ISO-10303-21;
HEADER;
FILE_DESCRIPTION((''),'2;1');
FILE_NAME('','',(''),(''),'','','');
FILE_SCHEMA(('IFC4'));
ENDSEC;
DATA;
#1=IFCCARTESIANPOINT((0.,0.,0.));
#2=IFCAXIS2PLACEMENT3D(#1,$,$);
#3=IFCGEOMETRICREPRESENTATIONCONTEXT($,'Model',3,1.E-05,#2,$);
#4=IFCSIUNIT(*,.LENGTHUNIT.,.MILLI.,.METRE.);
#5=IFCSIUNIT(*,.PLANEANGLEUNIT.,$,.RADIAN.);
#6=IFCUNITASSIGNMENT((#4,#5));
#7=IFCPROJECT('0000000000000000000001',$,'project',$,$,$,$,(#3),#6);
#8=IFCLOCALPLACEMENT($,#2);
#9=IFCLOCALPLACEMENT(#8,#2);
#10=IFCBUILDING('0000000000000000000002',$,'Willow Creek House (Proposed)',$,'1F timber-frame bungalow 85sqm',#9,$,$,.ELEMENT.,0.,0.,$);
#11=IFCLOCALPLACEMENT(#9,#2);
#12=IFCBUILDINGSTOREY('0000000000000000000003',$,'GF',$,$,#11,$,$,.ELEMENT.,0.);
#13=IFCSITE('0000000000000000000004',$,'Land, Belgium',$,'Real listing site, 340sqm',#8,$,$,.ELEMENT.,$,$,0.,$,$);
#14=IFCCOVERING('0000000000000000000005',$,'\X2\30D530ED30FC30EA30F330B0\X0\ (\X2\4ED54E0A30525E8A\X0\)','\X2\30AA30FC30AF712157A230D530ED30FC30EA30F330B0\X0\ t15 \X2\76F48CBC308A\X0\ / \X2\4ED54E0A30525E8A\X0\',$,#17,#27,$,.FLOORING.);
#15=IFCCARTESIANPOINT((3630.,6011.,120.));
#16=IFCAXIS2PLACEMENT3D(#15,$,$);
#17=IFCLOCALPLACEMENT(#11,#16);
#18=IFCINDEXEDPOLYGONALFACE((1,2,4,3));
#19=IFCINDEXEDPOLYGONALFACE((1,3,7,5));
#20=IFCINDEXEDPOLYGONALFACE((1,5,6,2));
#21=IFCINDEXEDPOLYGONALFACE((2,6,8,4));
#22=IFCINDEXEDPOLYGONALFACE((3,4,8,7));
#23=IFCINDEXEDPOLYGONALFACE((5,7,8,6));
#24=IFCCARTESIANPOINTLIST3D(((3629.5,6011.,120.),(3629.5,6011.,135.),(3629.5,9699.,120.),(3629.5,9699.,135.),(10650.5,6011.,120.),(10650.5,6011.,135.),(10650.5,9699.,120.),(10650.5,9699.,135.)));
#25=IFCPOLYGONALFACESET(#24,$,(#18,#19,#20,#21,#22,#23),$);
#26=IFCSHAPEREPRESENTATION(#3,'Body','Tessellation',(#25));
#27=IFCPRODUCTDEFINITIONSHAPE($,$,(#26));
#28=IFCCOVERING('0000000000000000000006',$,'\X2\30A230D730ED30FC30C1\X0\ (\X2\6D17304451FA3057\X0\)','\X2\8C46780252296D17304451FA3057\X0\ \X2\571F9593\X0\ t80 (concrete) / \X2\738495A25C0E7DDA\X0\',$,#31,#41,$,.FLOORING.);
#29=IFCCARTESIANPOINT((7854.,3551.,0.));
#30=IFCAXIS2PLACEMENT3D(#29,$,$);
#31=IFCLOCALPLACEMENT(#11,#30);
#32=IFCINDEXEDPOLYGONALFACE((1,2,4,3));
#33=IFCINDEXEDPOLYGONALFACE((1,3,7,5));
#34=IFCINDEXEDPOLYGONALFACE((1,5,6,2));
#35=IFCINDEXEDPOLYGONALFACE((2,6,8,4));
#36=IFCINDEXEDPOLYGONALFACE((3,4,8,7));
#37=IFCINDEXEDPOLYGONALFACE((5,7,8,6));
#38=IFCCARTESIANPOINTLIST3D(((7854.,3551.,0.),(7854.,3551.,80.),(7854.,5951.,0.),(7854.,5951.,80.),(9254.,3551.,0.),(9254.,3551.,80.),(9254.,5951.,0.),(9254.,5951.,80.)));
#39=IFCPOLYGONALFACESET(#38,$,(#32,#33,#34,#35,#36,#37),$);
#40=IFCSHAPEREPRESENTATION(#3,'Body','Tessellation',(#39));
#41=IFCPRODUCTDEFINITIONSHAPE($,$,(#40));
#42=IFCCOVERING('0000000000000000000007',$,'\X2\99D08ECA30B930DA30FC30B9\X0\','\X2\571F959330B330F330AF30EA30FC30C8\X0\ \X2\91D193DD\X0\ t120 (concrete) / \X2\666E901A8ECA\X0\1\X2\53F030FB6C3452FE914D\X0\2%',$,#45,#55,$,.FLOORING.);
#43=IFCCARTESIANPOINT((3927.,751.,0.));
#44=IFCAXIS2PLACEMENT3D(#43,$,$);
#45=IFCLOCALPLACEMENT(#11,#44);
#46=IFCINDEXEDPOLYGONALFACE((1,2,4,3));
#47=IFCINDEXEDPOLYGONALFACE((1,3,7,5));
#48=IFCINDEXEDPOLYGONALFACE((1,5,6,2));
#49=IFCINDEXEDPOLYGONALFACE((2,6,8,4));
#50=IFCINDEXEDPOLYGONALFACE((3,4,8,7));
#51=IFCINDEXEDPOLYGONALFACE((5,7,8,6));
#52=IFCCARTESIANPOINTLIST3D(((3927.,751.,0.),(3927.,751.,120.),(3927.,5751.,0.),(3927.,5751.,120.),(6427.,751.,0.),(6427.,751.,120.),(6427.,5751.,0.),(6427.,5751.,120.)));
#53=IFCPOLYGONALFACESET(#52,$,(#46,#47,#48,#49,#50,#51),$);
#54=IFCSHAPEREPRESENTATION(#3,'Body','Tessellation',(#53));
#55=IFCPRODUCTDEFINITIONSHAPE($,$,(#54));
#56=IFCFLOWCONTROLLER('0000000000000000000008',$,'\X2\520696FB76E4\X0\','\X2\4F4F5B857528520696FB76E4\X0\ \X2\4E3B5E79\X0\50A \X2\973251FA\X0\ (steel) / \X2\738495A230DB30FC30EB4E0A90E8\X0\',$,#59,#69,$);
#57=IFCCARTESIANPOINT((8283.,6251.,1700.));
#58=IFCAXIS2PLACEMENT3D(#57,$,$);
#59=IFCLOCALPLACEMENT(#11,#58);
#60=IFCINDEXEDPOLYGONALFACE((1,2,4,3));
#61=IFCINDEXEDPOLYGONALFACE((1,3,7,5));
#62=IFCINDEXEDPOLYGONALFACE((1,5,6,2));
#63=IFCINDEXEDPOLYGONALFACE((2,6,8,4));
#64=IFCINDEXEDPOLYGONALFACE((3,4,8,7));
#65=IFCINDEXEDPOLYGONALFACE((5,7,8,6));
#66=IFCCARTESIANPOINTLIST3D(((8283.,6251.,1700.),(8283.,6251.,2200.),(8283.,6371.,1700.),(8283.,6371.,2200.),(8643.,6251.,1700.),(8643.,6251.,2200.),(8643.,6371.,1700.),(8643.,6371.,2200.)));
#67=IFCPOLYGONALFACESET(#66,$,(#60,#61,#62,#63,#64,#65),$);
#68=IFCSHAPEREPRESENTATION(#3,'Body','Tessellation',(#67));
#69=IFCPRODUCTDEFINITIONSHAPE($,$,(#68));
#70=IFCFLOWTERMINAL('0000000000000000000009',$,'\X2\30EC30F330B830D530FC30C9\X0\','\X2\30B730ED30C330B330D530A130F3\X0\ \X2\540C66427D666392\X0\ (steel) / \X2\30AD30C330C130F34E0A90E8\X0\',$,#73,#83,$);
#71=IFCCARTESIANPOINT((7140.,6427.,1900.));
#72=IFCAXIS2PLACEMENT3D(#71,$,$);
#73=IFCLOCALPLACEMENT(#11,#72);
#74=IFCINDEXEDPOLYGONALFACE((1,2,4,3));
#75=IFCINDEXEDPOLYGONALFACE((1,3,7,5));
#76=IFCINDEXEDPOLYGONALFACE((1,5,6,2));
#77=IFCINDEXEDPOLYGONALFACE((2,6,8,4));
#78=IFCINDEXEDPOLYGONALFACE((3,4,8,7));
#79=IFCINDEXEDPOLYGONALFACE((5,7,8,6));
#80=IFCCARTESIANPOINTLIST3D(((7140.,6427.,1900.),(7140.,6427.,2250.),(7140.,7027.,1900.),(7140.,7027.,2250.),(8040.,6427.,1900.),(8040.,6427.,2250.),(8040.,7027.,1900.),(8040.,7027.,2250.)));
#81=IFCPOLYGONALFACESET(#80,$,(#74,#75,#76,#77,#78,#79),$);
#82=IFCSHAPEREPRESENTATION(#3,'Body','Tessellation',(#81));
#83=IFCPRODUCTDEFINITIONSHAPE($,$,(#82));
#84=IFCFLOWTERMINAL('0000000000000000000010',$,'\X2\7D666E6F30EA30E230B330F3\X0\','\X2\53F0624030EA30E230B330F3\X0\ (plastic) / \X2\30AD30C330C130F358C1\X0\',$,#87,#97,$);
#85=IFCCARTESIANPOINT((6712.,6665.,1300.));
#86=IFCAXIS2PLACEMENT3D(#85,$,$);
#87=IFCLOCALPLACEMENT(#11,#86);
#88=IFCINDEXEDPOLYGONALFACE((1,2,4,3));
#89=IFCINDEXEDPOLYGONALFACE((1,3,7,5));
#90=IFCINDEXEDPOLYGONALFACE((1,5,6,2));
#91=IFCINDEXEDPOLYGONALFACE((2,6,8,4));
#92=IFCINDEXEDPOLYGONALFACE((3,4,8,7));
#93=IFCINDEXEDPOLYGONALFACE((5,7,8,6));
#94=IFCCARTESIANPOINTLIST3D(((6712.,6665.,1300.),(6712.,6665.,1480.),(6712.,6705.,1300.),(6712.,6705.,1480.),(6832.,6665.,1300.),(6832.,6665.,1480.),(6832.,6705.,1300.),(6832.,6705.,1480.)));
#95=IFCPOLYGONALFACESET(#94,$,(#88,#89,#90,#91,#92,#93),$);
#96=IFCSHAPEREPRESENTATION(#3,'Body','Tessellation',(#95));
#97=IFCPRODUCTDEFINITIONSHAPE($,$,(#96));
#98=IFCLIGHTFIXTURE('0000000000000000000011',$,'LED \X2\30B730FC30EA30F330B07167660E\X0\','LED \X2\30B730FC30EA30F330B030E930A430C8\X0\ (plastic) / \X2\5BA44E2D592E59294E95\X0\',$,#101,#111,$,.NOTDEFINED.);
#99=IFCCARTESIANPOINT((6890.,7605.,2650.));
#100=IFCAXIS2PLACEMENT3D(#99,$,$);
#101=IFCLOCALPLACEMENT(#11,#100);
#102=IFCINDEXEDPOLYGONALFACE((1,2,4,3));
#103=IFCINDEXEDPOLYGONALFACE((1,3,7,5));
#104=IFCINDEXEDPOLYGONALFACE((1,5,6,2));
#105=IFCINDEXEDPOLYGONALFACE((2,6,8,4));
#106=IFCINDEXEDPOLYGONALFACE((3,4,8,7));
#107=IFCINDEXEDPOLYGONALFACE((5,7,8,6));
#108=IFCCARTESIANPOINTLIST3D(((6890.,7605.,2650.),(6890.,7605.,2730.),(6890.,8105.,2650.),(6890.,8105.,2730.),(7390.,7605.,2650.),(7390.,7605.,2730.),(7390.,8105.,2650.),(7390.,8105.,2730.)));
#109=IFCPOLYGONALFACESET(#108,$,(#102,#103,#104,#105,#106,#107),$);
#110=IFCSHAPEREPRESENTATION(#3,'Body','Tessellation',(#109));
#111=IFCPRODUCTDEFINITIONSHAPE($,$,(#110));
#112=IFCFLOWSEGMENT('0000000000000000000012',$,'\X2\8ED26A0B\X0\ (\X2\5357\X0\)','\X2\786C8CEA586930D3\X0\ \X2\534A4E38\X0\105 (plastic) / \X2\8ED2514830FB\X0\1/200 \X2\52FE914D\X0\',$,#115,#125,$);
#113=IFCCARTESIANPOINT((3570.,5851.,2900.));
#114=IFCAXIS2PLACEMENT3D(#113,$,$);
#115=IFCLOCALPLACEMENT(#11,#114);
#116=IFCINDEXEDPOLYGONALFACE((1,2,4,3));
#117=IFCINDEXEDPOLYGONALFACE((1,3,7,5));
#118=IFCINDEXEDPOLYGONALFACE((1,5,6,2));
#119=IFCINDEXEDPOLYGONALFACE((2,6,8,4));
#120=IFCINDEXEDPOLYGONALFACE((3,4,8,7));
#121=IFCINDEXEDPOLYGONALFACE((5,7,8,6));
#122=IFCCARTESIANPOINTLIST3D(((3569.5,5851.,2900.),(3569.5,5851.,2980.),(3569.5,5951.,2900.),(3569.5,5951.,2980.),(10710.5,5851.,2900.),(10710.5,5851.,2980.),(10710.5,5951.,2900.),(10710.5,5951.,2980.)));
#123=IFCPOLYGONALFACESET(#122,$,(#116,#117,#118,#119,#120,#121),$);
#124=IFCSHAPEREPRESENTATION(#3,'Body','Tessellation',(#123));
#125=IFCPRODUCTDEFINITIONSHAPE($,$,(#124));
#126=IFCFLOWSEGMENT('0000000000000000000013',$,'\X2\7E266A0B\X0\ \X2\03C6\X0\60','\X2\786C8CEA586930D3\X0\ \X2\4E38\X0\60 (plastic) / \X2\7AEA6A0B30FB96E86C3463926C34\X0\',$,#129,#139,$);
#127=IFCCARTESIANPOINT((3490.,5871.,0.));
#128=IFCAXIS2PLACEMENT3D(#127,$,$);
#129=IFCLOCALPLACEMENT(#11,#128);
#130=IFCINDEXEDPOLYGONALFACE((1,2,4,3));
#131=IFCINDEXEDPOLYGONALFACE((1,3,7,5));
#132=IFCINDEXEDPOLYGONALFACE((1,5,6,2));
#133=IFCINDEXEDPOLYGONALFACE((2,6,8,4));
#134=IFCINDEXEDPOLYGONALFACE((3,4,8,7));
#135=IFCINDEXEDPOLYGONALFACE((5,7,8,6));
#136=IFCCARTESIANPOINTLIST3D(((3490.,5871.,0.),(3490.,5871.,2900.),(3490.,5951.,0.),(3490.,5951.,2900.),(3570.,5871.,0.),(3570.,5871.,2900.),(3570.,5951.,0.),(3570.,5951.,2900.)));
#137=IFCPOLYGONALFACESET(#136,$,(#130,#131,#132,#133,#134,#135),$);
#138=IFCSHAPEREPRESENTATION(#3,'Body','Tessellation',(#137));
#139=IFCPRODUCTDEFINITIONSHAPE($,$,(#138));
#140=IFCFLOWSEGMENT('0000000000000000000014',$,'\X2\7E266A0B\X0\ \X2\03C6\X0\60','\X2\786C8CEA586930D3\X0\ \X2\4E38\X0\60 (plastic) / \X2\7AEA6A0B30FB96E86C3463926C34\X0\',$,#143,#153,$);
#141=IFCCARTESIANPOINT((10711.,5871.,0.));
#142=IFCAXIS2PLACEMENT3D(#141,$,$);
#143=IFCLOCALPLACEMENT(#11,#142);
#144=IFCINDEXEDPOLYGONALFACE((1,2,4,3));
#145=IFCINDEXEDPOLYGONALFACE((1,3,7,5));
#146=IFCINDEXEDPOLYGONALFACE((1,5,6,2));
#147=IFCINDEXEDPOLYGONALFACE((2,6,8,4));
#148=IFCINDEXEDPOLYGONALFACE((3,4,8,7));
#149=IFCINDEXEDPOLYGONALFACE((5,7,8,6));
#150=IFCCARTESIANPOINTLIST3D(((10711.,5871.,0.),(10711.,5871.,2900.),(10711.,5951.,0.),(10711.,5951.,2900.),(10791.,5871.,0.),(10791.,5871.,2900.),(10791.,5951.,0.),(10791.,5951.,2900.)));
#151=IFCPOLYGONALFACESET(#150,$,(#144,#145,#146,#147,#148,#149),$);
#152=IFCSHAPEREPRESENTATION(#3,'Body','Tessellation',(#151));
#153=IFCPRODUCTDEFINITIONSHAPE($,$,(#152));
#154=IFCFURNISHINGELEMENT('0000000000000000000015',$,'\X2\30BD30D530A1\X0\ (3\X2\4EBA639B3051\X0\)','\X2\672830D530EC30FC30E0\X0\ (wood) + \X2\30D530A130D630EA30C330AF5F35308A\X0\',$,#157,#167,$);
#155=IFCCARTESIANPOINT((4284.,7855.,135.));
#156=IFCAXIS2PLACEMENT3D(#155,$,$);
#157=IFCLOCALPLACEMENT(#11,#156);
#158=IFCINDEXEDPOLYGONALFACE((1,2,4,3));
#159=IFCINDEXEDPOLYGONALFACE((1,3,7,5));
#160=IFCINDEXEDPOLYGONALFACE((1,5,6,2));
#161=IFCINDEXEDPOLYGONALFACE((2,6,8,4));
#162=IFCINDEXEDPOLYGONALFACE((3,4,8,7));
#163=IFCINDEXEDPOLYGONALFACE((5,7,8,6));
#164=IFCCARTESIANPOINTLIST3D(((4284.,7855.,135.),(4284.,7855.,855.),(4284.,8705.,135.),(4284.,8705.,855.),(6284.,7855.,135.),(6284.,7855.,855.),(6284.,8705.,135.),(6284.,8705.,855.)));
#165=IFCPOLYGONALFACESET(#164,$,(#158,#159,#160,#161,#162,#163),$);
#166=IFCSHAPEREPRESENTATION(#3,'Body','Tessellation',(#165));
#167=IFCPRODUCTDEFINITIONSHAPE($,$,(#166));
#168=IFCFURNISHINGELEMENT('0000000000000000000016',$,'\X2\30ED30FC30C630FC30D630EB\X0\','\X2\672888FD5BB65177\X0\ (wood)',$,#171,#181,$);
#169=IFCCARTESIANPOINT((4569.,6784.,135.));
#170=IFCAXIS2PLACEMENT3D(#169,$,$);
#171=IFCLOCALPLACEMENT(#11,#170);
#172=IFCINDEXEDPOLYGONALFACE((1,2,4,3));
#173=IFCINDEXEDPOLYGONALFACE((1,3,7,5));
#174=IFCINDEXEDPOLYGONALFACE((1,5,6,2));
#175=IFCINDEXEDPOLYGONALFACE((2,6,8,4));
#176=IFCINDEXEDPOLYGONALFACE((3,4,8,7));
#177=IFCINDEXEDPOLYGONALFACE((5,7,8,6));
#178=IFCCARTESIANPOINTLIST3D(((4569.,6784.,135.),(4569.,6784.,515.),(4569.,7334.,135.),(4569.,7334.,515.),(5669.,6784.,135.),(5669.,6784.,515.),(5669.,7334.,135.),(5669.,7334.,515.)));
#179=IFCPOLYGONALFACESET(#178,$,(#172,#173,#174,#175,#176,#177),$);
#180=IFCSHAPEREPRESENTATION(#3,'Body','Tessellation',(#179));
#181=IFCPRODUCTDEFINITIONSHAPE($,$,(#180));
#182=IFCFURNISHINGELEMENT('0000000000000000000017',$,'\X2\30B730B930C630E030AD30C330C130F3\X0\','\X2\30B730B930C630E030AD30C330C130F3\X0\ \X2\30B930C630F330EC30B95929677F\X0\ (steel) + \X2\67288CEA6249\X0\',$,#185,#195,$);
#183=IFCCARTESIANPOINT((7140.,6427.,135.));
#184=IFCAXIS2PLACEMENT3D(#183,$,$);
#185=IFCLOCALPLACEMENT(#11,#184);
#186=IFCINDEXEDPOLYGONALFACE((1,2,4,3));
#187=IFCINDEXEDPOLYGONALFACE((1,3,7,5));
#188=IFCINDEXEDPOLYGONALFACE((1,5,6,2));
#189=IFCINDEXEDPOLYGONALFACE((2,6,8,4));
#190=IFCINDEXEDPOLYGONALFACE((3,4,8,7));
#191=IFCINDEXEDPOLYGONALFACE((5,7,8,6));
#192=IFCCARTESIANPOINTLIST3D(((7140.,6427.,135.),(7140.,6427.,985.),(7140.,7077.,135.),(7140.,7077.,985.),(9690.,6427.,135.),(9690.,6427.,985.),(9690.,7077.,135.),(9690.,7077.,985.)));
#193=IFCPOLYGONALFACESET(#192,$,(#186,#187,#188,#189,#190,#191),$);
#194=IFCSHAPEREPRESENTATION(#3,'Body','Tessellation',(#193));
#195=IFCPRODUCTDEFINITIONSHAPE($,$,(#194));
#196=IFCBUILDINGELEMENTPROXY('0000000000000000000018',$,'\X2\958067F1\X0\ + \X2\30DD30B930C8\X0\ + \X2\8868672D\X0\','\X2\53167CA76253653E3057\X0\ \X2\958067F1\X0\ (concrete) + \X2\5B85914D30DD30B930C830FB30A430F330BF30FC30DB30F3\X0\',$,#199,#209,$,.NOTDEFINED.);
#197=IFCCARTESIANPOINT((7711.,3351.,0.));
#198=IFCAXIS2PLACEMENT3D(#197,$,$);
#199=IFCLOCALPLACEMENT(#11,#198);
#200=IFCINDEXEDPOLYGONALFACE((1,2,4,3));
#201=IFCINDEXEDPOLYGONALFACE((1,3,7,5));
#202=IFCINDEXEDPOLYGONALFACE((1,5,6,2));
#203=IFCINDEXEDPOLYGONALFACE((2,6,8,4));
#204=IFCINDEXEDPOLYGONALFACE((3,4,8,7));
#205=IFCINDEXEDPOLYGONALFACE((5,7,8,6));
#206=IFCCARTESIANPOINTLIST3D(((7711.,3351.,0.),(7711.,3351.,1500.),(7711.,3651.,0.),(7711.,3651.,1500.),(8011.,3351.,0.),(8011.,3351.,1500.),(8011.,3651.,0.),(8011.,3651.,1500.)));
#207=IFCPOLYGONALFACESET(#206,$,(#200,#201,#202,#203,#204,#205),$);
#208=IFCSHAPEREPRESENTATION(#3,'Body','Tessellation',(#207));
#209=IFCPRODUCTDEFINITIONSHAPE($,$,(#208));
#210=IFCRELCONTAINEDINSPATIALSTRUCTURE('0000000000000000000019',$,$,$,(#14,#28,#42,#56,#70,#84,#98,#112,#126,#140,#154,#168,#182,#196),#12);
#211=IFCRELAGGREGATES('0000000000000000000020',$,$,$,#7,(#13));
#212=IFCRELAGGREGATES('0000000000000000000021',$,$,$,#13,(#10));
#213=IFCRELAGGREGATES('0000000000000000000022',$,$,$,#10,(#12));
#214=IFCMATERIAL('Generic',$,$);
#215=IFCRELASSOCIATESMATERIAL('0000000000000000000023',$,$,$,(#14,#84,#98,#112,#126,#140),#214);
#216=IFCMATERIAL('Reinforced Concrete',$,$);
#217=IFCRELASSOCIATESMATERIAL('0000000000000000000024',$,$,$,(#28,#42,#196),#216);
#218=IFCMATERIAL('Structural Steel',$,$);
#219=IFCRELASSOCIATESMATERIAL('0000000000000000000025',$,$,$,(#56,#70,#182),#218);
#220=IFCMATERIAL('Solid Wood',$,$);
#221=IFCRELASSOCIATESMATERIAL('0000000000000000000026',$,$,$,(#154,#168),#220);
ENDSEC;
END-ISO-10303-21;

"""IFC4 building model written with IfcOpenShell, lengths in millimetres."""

from ifc_helpers import new_model, si_unit, frame, frame_2d, origin, place, context, project, spatial, rectangle, extrude, material, element, save


model = new_model("IFC4")

# Units and contexts
model_context = context("Model", 3, precision=1e-05, world=origin())
ifc_project = project(units=[si_unit("LENGTHUNIT", "METRE", prefix="MILLI"), si_unit("PLANEANGLEUNIT", "RADIAN")], contexts=[model_context])

# Site, building, storey
site_placement = place(None, origin())
site = spatial("IfcSite", under=ifc_project, at=site_placement, Name="Land, Belgium", ObjectType="Real listing site, 340sqm", CompositionType="ELEMENT", RefElevation=0.0)
building_placement = place(site_placement, origin())
building = spatial("IfcBuilding", under=site, at=building_placement, Name="Willow Creek House (Proposed)", ObjectType="1F timber-frame bungalow 85sqm", CompositionType="ELEMENT", ElevationOfRefHeight=0.0, ElevationOfTerrain=0.0)
storey_placement = place(building_placement, origin())
storey = spatial("IfcBuildingStorey", under=building, at=storey_placement, Name="GF", CompositionType="ELEMENT", Elevation=0.0)

# Shared definitions
ifc_material_1 = material(Name="Solid Wood")

# Shared definitions
ifc_material_2 = material(Name="Reinforced Concrete")

# Shared definitions
ifc_material_3 = material(Name="Structural Steel")

# Coverings
ifc_material_4 = material(Name="Generic")
covering_1_placement = place(storey_placement, frame((3630.0, 6011.0, 120.0)))
element("IfcCovering", 1, at=covering_1_placement, inside=storey, material=ifc_material_4, Name="フローリング (仕上げ床)", Description="オーク無垢フローリング t15 直貼り / 仕上げ床", PredefinedType="FLOORING", context=model_context, shape_type="SweptSolid", body=[
    extrude(rectangle(XDim=7021.0, YDim=3688.0, at=frame_2d((3510.0, 1844.0))), frame((3630.0, 6011.0, 120.0)), (0.0, 0.0, 1.0), 15.0),
])
covering_2_placement = place(storey_placement, frame((7854.0, 3551.0, 0.0)))
element("IfcCovering", 2, at=covering_2_placement, inside=storey, material=ifc_material_2, Name="アプローチ (洗い出し)", Description="豆砂利洗い出し 土間 t80 (concrete) / 玄関導線", PredefinedType="FLOORING", context=model_context, shape_type="SweptSolid", body=[
    extrude(rectangle(XDim=1400.0, YDim=2400.0, at=frame_2d((700.0, 1200.0))), frame((7854.0, 3551.0, 0.0)), (0.0, 0.0, 1.0), 80.0),
])
covering_3_placement = place(storey_placement, frame((3927.0, 751.0, 0.0)))
element("IfcCovering", 3, at=covering_3_placement, inside=storey, material=ifc_material_2, Name="駐車スペース", Description="土間コンクリート 金鏝 t120 (concrete) / 普通車1台・水勾配2%", PredefinedType="FLOORING", context=model_context, shape_type="SweptSolid", body=[
    extrude(rectangle(XDim=2500.0, YDim=5000.0, at=frame_2d((1250.0, 2500.0))), frame((3927.0, 751.0, 0.0)), (0.0, 0.0, 1.0), 120.0),
])

# Flow controller
flow_controller_placement = place(storey_placement, frame((8283.0, 6251.0, 1700.0)))
element("IfcFlowController", 4, at=flow_controller_placement, inside=storey, material=ifc_material_3, Name="分電盤", Description="住宅用分電盤 主幹50A 露出 (steel) / 玄関ホール上部", context=model_context, shape_type="SweptSolid", body=[
    extrude(rectangle(XDim=360.0, YDim=120.0, at=frame_2d((180.0, 60.0))), frame((8283.0, 6251.0, 1700.0)), (0.0, 0.0, 1.0), 500.0),
])

# Flow terminals
flow_terminal_1_placement = place(storey_placement, frame((7140.0, 6427.0, 1900.0)))
element("IfcFlowTerminal", 5, at=flow_terminal_1_placement, inside=storey, material=ifc_material_3, Name="レンジフード", Description="シロッコファン 同時給排 (steel) / キッチン上部", context=model_context, shape_type="SweptSolid", body=[
    extrude(rectangle(XDim=900.0, YDim=600.0, at=frame_2d((450.0, 300.0))), frame((7140.0, 6427.0, 1900.0)), (0.0, 0.0, 1.0), 350.0),
])
flow_terminal_2_placement = place(storey_placement, frame((6712.0, 6665.0, 1300.0)))
element("IfcFlowTerminal", 6, at=flow_terminal_2_placement, inside=storey, material=ifc_material_4, Name="給湯リモコン", Description="台所リモコン (plastic) / キッチン壁", context=model_context, shape_type="SweptSolid", body=[
    extrude(rectangle(XDim=120.0, YDim=40.0, at=frame_2d((60.0, 20.0))), frame((6712.0, 6665.0, 1300.0)), (0.0, 0.0, 1.0), 180.0),
])

# Light fixture
light_fixture_placement = place(storey_placement, frame((6890.0, 7605.0, 2650.0)))
element("IfcLightFixture", 7, at=light_fixture_placement, inside=storey, material=ifc_material_4, Name="LED シーリング照明", Description="LED シーリングライト (plastic) / 室中央天井", PredefinedType="NOTDEFINED", context=model_context, shape_type="SweptSolid", body=[
    extrude(rectangle(XDim=500.0, YDim=500.0, at=frame_2d((250.0, 250.0))), frame((6890.0, 7605.0, 2650.0)), (0.0, 0.0, 1.0), 80.0),
])

# Flow segments
flow_segment_1_placement = place(storey_placement, frame((3570.0, 5851.0, 2900.0)))
element("IfcFlowSegment", 8, at=flow_segment_1_placement, inside=storey, material=ifc_material_4, Name="軒樋 (南)", Description="硬質塩ビ 半丸105 (plastic) / 軒先・1/200 勾配", context=model_context, shape_type="SweptSolid", body=[
    extrude(rectangle(XDim=7141.0, YDim=100.0, at=frame_2d((3570.0, 50.0))), frame((3570.0, 5851.0, 2900.0)), (0.0, 0.0, 1.0), 80.0),
])
flow_segment_2_placement = place(storey_placement, frame((3490.0, 5871.0, 0.0)))
element("IfcFlowSegment", 9, at=flow_segment_2_placement, inside=storey, material=ifc_material_4, Name="縦樋 φ60", Description="硬質塩ビ 丸60 (plastic) / 竪樋・雨水排水", context=model_context, shape_type="SweptSolid", body=[
    extrude(rectangle(XDim=80.0, YDim=80.0, at=frame_2d((40.0, 40.0))), frame((3490.0, 5871.0, 0.0)), (0.0, 0.0, 1.0), 2900.0),
])
flow_segment_3_placement = place(storey_placement, frame((10711.0, 5871.0, 0.0)))
element("IfcFlowSegment", 10, at=flow_segment_3_placement, inside=storey, material=ifc_material_4, Name="縦樋 φ60", Description="硬質塩ビ 丸60 (plastic) / 竪樋・雨水排水", context=model_context, shape_type="SweptSolid", body=[
    extrude(rectangle(XDim=80.0, YDim=80.0, at=frame_2d((40.0, 40.0))), frame((10711.0, 5871.0, 0.0)), (0.0, 0.0, 1.0), 2900.0),
])

# Furnishing elements
furnishing_1_placement = place(storey_placement, frame((4284.0, 7855.0, 135.0)))
element("IfcFurnishingElement", 11, at=furnishing_1_placement, inside=storey, material=ifc_material_1, Name="ソファ (3人掛け)", Description="木フレーム (wood) + ファブリック張り", context=model_context, shape_type="SweptSolid", body=[
    extrude(rectangle(XDim=2000.0, YDim=850.0, at=frame_2d((1000.0, 425.0))), frame((4284.0, 7855.0, 135.0)), (0.0, 0.0, 1.0), 720.0),
])
furnishing_2_placement = place(storey_placement, frame((4569.0, 6784.0, 135.0)))
element("IfcFurnishingElement", 12, at=furnishing_2_placement, inside=storey, material=ifc_material_1, Name="ローテーブル", Description="木製家具 (wood)", context=model_context, shape_type="SweptSolid", body=[
    extrude(rectangle(XDim=1100.0, YDim=550.0, at=frame_2d((550.0, 275.0))), frame((4569.0, 6784.0, 135.0)), (0.0, 0.0, 1.0), 380.0),
])
furnishing_3_placement = place(storey_placement, frame((7140.0, 6427.0, 135.0)))
element("IfcFurnishingElement", 13, at=furnishing_3_placement, inside=storey, material=ifc_material_3, Name="システムキッチン", Description="システムキッチン ステンレス天板 (steel) + 木質扉", context=model_context, shape_type="SweptSolid", body=[
    extrude(rectangle(XDim=2550.0, YDim=650.0, at=frame_2d((1275.0, 325.0))), frame((7140.0, 6427.0, 135.0)), (0.0, 0.0, 1.0), 850.0),
])

# Building element proxy
proxy_placement = place(storey_placement, frame((7711.0, 3351.0, 0.0)))
element("IfcBuildingElementProxy", 14, at=proxy_placement, inside=storey, material=ifc_material_2, Name="門柱 + ポスト + 表札", Description="化粧打放し 門柱 (concrete) + 宅配ポスト・インターホン", PredefinedType="NOTDEFINED", context=model_context, shape_type="SweptSolid", body=[
    extrude(rectangle(XDim=300.0, YDim=300.0, at=frame_2d((150.0, 150.0))), frame((7711.0, 3351.0, 0.0)), (0.0, 0.0, 1.0), 1500.0),
])

save(model, "model.ifc")
